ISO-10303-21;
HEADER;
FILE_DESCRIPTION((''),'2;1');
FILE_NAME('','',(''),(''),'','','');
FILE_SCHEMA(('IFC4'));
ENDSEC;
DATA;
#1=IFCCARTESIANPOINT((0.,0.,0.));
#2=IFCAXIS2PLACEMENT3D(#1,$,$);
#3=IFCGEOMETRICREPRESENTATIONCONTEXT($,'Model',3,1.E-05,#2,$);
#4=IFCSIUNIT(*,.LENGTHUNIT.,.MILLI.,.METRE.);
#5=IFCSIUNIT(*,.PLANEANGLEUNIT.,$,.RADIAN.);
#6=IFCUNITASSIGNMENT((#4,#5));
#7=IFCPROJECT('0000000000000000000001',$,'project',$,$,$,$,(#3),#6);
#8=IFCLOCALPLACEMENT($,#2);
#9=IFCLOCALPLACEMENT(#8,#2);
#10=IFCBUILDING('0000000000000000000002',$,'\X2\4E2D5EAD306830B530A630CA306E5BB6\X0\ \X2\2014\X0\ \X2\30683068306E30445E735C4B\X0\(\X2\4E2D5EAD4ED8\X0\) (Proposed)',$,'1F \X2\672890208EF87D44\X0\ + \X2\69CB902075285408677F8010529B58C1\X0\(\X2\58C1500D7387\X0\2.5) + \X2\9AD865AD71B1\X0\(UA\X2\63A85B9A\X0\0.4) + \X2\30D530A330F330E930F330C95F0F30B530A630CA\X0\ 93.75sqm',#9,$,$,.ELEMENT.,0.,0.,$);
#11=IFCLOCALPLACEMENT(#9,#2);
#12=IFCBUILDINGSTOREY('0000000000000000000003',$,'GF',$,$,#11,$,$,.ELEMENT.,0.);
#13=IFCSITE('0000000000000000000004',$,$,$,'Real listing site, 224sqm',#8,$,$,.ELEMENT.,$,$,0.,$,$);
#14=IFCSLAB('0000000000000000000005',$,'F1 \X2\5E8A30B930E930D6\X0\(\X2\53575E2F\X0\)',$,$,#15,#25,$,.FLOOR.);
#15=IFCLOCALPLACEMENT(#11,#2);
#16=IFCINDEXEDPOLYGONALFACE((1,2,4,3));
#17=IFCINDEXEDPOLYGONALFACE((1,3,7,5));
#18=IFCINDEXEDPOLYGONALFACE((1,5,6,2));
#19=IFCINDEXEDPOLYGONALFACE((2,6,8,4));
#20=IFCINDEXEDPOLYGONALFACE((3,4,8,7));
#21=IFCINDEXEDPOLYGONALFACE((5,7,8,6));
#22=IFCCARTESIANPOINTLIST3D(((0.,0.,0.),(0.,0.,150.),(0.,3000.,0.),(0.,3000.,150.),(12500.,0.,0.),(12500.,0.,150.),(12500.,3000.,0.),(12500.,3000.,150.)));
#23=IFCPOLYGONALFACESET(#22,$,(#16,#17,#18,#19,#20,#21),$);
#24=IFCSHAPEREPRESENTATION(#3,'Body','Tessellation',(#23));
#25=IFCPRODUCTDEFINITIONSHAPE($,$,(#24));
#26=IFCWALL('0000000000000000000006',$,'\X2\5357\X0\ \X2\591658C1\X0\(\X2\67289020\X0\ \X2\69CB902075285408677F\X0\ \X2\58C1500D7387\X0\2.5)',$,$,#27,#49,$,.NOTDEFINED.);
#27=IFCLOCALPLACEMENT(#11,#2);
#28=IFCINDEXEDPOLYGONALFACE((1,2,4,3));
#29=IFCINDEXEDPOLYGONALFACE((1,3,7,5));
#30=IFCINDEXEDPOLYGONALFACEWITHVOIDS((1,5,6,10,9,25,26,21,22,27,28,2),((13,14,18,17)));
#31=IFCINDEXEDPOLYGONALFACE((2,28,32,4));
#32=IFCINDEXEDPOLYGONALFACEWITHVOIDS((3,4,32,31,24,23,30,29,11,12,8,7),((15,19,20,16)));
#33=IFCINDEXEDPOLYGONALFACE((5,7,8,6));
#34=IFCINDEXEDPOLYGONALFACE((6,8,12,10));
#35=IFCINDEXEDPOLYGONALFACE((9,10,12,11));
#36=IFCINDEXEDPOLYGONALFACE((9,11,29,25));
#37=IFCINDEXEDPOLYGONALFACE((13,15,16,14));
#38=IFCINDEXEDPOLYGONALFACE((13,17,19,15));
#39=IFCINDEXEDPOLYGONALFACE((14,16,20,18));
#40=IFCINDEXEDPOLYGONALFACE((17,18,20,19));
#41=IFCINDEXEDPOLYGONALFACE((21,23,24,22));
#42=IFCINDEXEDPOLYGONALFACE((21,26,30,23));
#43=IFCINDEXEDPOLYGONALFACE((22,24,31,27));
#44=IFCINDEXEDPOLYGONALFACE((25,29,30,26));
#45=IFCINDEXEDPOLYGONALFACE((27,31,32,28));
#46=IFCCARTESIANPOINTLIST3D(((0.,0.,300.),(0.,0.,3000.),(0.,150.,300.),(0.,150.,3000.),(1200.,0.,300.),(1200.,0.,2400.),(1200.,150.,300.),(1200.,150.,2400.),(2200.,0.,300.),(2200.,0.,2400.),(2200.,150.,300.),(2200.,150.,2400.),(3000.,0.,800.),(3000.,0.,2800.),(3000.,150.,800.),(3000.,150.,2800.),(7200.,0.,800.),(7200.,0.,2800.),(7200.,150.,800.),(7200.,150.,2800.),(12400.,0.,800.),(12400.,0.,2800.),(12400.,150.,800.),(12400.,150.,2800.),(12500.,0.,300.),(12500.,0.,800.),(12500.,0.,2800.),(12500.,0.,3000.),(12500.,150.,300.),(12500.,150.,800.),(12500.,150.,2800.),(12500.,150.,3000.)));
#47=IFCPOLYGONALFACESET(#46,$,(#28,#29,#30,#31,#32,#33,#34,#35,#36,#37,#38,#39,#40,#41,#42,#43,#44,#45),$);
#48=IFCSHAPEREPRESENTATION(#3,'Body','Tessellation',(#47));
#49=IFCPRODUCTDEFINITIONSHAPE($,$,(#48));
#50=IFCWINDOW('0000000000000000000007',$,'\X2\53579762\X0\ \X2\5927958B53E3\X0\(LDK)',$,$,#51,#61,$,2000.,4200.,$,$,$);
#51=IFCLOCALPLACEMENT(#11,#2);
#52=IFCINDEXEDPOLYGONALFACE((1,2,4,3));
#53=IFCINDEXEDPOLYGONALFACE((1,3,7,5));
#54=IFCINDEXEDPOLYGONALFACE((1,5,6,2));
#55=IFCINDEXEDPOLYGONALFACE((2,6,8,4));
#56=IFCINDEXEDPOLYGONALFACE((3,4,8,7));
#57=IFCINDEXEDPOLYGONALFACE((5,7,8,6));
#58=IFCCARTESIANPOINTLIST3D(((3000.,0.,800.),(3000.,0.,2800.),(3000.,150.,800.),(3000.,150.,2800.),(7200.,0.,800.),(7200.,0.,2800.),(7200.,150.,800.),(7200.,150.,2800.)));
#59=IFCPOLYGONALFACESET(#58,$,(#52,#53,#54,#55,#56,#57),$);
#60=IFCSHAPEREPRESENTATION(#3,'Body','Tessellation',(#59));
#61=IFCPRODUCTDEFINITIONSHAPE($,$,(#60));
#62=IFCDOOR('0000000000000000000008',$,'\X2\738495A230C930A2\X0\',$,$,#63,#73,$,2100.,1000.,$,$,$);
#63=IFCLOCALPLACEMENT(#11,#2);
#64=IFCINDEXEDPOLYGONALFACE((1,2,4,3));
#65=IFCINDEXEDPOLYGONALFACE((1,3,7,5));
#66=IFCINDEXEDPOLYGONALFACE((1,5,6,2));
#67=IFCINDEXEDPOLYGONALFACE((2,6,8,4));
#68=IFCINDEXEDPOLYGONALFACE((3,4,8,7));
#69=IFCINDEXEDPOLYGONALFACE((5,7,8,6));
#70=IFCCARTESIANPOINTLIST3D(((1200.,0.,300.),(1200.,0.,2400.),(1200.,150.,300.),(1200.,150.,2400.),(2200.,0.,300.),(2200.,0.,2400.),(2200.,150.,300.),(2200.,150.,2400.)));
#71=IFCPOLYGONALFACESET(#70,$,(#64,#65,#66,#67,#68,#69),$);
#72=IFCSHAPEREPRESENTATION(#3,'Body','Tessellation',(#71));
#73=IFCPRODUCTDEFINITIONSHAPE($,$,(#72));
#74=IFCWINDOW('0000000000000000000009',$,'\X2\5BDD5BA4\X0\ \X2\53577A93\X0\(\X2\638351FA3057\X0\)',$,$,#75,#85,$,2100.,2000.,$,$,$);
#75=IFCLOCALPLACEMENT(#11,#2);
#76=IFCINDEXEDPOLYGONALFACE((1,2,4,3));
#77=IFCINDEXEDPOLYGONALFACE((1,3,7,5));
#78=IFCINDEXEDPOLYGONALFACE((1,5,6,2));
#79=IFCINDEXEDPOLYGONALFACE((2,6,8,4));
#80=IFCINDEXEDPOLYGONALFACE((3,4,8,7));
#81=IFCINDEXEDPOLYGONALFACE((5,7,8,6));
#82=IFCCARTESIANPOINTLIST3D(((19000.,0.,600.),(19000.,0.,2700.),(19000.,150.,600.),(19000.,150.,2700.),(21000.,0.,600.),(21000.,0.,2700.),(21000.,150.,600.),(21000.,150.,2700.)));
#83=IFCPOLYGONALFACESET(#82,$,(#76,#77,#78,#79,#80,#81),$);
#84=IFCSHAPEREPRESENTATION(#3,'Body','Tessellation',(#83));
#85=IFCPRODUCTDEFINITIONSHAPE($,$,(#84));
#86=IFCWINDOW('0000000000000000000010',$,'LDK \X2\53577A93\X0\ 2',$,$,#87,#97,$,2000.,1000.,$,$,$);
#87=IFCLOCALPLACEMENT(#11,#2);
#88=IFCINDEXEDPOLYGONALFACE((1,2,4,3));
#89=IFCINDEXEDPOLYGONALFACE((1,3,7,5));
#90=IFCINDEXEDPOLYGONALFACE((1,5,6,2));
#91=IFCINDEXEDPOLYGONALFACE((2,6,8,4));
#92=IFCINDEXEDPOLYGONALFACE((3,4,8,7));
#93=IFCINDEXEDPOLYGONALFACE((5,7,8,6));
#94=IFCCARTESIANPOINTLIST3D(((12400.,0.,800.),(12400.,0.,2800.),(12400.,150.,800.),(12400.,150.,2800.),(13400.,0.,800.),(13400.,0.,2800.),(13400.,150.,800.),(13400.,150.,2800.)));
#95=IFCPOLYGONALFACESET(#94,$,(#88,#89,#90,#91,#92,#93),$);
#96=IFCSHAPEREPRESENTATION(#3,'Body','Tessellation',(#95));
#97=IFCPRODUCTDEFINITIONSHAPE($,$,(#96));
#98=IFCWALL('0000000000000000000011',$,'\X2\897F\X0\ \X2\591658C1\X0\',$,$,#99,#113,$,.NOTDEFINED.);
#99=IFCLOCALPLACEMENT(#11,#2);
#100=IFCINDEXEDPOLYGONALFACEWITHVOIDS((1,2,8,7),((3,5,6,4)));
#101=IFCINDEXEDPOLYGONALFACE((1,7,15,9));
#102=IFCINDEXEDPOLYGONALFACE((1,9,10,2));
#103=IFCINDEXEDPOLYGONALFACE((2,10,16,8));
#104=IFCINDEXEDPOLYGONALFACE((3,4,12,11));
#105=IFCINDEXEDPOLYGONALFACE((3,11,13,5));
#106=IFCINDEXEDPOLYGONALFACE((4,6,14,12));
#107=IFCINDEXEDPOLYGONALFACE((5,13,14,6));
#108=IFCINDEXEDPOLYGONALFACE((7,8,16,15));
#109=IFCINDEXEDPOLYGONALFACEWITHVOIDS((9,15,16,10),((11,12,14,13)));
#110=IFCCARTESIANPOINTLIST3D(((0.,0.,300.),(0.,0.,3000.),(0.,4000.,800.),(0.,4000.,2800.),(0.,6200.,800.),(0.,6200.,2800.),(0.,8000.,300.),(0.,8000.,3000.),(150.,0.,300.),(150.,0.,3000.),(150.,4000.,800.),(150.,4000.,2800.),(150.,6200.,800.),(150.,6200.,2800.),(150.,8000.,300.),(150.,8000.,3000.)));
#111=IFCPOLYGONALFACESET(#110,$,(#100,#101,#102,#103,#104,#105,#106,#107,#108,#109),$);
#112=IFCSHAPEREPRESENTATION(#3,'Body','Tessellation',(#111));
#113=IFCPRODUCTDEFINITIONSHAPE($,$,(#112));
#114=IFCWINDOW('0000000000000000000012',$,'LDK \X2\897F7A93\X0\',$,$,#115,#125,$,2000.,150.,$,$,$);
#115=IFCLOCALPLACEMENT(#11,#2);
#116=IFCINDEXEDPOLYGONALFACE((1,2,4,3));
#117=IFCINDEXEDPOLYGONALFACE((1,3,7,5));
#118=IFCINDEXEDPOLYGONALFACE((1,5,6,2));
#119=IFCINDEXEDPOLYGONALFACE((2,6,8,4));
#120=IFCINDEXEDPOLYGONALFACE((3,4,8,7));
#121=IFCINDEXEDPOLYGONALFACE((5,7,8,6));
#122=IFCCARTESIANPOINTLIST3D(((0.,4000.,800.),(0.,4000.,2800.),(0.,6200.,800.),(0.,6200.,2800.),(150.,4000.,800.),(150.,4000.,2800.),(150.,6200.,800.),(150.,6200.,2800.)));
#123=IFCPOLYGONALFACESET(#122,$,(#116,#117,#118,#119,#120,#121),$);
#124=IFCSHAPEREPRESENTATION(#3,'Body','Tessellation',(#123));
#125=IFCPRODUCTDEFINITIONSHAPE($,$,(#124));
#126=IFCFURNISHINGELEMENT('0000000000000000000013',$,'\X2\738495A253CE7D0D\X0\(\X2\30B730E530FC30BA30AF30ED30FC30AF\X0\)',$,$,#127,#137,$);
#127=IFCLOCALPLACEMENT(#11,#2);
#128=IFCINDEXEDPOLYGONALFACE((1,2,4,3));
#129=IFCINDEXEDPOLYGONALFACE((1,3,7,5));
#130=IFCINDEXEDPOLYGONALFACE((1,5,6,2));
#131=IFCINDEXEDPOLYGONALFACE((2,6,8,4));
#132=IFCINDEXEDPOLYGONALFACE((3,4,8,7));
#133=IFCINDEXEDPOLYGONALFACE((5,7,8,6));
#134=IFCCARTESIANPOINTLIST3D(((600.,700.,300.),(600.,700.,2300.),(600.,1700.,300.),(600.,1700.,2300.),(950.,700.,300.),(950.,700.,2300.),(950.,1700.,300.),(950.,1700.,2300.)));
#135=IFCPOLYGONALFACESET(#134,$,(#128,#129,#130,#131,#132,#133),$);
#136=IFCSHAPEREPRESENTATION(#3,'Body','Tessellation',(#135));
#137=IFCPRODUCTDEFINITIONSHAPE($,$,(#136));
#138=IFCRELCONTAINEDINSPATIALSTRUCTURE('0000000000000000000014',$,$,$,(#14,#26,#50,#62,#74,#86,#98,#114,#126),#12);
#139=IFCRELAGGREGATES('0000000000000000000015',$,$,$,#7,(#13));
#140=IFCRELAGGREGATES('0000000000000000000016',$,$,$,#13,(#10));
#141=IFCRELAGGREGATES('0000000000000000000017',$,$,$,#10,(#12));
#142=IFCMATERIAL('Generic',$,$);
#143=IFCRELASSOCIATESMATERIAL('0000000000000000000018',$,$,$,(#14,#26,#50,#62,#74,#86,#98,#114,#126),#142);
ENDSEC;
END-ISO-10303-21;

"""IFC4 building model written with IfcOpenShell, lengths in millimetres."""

from ifc_helpers import new_model, si_unit, frame, frame_2d, origin, place, context, project, spatial, rectangle, extrude, material, element, fill, save


model = new_model("IFC4")

# Units and contexts
model_context = context("Model", 3, precision=1e-05, world=origin())
ifc_project = project(units=[si_unit("LENGTHUNIT", "METRE", prefix="MILLI"), si_unit("PLANEANGLEUNIT", "RADIAN")], contexts=[model_context])

# Site, building, storey
site_placement = place(None, origin())
site = spatial("IfcSite", under=ifc_project, at=site_placement, ObjectType="Real listing site, 224sqm", CompositionType="ELEMENT", RefElevation=0.0)
building_placement = place(site_placement, origin())
building = spatial("IfcBuilding", under=site, at=building_placement, Name="中庭とサウナの家 — ととのい平屋(中庭付) (Proposed)", ObjectType="1F 木造軸組 + 構造用合板耐力壁(壁倍率2.5) + 高断熱(UA推定0.4) + フィンランド式サウナ 93.75sqm", CompositionType="ELEMENT", ElevationOfRefHeight=0.0, ElevationOfTerrain=0.0)
storey_placement = place(building_placement, origin())
storey = spatial("IfcBuildingStorey", under=building, at=storey_placement, Name="GF", CompositionType="ELEMENT", Elevation=0.0)

# Slab
ifc_material = material(Name="Generic")
slab_1_placement = place(storey_placement, origin())
element("IfcSlab", 1, at=slab_1_placement, inside=storey, material=ifc_material, Name="F1 床スラブ(南帯)", PredefinedType="FLOOR", context=model_context, shape_type="SweptSolid", body=[
    extrude(rectangle(XDim=12500.0, YDim=3000.0, at=frame_2d((6250.0, 1500.0))), origin(), (0.0, 0.0, 1.0), 150.0),
])

# Wall, openings, windows, door
wall_1_placement = place(storey_placement, frame((0.0, 0.0, 150.0)))
wall_1 = element("IfcWall", 2, at=wall_1_placement, inside=storey, material=ifc_material, Name="南 外壁(木造 構造用合板 壁倍率2.5)", PredefinedType="NOTDEFINED", context=model_context, shape_type="SweptSolid", body=[
    extrude(rectangle(XDim=12500.0, YDim=150.0, at=frame_2d((6250.0, 75.0))), frame((0.0, 0.0, 150.0)), (0.0, 0.0, 1.0), 2700.0),
])
opening_1_placement = place(storey_placement, frame((1500.0, 0.0, 400.0)))
opening_1 = element("IfcOpeningElement", 3, at=opening_1_placement, cuts=wall_1, PredefinedType="NOTDEFINED", context=model_context, shape_type="SweptSolid", body=[
    extrude(rectangle(XDim=4200.0, YDim=150.0, at=frame_2d((2100.0, 75.0))), frame((1500.0, 0.0, 400.0)), (0.0, 0.0, 1.0), 2000.0),
])
opening_2_placement = place(storey_placement, frame((600.0, 0.0, 150.0)))
opening_2 = element("IfcOpeningElement", 4, at=opening_2_placement, cuts=wall_1, PredefinedType="NOTDEFINED", context=model_context, shape_type="SweptSolid", body=[
    extrude(rectangle(XDim=1000.0, YDim=150.0, at=frame_2d((500.0, 75.0))), frame((600.0, 0.0, 150.0)), (0.0, 0.0, 1.0), 2100.0),
])
opening_3_placement = place(storey_placement, frame((9500.0, 0.0, 300.0)))
opening_3 = element("IfcOpeningElement", 5, at=opening_3_placement, cuts=wall_1, PredefinedType="NOTDEFINED", context=model_context, shape_type="SweptSolid", body=[
    extrude(rectangle(XDim=2000.0, YDim=150.0, at=frame_2d((1000.0, 75.0))), frame((9500.0, 0.0, 300.0)), (0.0, 0.0, 1.0), 2100.0),
])
opening_4_placement = place(storey_placement, frame((6200.0, 0.0, 400.0)))
opening_4 = element("IfcOpeningElement", 6, at=opening_4_placement, cuts=wall_1, PredefinedType="NOTDEFINED", context=model_context, shape_type="SweptSolid", body=[
    extrude(rectangle(XDim=1000.0, YDim=150.0, at=frame_2d((500.0, 75.0))), frame((6200.0, 0.0, 400.0)), (0.0, 0.0, 1.0), 2000.0),
])
window_1_placement = place(storey_placement, frame((1500.0, 0.0, 400.0)))
window_1 = element("IfcWindow", 7, at=window_1_placement, inside=storey, material=ifc_material, Name="南面 大開口(LDK)", OverallHeight=2000.0, OverallWidth=4200.0, context=model_context, shape_type="SweptSolid", body=[
    extrude(rectangle(XDim=4200.0, YDim=150.0, at=frame_2d((2100.0, 75.0))), frame((1500.0, 0.0, 400.0)), (0.0, 0.0, 1.0), 2000.0),
])
fill(opening_1, window_1)
door_placement = place(storey_placement, frame((600.0, 0.0, 150.0)))
door = element("IfcDoor", 8, at=door_placement, inside=storey, material=ifc_material, Name="玄関ドア", OverallHeight=2100.0, OverallWidth=1000.0, context=model_context, shape_type="SweptSolid", body=[
    extrude(rectangle(XDim=1000.0, YDim=150.0, at=frame_2d((500.0, 75.0))), frame((600.0, 0.0, 150.0)), (0.0, 0.0, 1.0), 2100.0),
])
fill(opening_2, door)
window_2_placement = place(storey_placement, frame((9500.0, 0.0, 300.0)))
window_2 = element("IfcWindow", 9, at=window_2_placement, inside=storey, material=ifc_material, Name="寝室 南窓(掃出し)", OverallHeight=2100.0, OverallWidth=2000.0, context=model_context, shape_type="SweptSolid", body=[
    extrude(rectangle(XDim=2000.0, YDim=150.0, at=frame_2d((1000.0, 75.0))), frame((9500.0, 0.0, 300.0)), (0.0, 0.0, 1.0), 2100.0),
])
fill(opening_3, window_2)
window_3_placement = place(storey_placement, frame((6200.0, 0.0, 400.0)))
window_3 = element("IfcWindow", 10, at=window_3_placement, inside=storey, material=ifc_material, Name="LDK 南窓 2", OverallHeight=2000.0, OverallWidth=1000.0, context=model_context, shape_type="SweptSolid", body=[
    extrude(rectangle(XDim=1000.0, YDim=150.0, at=frame_2d((500.0, 75.0))), frame((6200.0, 0.0, 400.0)), (0.0, 0.0, 1.0), 2000.0),
])
fill(opening_4, window_3)

# Wall, opening, window
wall_2_placement = place(storey_placement, frame((0.0, 0.0, 150.0)))
wall_2 = element("IfcWall", 11, at=wall_2_placement, inside=storey, material=ifc_material, Name="西 外壁", PredefinedType="NOTDEFINED", context=model_context, shape_type="SweptSolid", body=[
    extrude(rectangle(XDim=150.0, YDim=8000.0, at=frame_2d((75.0, 4000.0))), frame((0.0, 0.0, 150.0)), (0.0, 0.0, 1.0), 2700.0),
])
opening_5_placement = place(storey_placement, frame((0.0, 2000.0, 400.0)))
opening_5 = element("IfcOpeningElement", 12, at=opening_5_placement, cuts=wall_2, PredefinedType="NOTDEFINED", context=model_context, shape_type="SweptSolid", body=[
    extrude(rectangle(XDim=150.0, YDim=2200.0, at=frame_2d((75.0, 1100.0))), frame((0.0, 2000.0, 400.0)), (0.0, 0.0, 1.0), 2000.0),
])
window_4_placement = place(storey_placement, frame((0.0, 2000.0, 400.0)))
window_4 = element("IfcWindow", 13, at=window_4_placement, inside=storey, material=ifc_material, Name="LDK 西窓", OverallHeight=2000.0, OverallWidth=150.0, context=model_context, shape_type="SweptSolid", body=[
    extrude(rectangle(XDim=150.0, YDim=2200.0, at=frame_2d((75.0, 1100.0))), frame((0.0, 2000.0, 400.0)), (0.0, 0.0, 1.0), 2000.0),
])
fill(opening_5, window_4)

# Furnishing element
furnishing_1_placement = place(storey_placement, frame((300.0, 350.0, 150.0)))
element("IfcFurnishingElement", 14, at=furnishing_1_placement, inside=storey, material=ifc_material, Name="玄関収納(シューズクローク)", context=model_context, shape_type="SweptSolid", body=[
    extrude(rectangle(XDim=350.0, YDim=1000.0, at=frame_2d((175.0, 500.0))), frame((300.0, 350.0, 150.0)), (0.0, 0.0, 1.0), 2000.0),
])

save(model, "model.ifc")
